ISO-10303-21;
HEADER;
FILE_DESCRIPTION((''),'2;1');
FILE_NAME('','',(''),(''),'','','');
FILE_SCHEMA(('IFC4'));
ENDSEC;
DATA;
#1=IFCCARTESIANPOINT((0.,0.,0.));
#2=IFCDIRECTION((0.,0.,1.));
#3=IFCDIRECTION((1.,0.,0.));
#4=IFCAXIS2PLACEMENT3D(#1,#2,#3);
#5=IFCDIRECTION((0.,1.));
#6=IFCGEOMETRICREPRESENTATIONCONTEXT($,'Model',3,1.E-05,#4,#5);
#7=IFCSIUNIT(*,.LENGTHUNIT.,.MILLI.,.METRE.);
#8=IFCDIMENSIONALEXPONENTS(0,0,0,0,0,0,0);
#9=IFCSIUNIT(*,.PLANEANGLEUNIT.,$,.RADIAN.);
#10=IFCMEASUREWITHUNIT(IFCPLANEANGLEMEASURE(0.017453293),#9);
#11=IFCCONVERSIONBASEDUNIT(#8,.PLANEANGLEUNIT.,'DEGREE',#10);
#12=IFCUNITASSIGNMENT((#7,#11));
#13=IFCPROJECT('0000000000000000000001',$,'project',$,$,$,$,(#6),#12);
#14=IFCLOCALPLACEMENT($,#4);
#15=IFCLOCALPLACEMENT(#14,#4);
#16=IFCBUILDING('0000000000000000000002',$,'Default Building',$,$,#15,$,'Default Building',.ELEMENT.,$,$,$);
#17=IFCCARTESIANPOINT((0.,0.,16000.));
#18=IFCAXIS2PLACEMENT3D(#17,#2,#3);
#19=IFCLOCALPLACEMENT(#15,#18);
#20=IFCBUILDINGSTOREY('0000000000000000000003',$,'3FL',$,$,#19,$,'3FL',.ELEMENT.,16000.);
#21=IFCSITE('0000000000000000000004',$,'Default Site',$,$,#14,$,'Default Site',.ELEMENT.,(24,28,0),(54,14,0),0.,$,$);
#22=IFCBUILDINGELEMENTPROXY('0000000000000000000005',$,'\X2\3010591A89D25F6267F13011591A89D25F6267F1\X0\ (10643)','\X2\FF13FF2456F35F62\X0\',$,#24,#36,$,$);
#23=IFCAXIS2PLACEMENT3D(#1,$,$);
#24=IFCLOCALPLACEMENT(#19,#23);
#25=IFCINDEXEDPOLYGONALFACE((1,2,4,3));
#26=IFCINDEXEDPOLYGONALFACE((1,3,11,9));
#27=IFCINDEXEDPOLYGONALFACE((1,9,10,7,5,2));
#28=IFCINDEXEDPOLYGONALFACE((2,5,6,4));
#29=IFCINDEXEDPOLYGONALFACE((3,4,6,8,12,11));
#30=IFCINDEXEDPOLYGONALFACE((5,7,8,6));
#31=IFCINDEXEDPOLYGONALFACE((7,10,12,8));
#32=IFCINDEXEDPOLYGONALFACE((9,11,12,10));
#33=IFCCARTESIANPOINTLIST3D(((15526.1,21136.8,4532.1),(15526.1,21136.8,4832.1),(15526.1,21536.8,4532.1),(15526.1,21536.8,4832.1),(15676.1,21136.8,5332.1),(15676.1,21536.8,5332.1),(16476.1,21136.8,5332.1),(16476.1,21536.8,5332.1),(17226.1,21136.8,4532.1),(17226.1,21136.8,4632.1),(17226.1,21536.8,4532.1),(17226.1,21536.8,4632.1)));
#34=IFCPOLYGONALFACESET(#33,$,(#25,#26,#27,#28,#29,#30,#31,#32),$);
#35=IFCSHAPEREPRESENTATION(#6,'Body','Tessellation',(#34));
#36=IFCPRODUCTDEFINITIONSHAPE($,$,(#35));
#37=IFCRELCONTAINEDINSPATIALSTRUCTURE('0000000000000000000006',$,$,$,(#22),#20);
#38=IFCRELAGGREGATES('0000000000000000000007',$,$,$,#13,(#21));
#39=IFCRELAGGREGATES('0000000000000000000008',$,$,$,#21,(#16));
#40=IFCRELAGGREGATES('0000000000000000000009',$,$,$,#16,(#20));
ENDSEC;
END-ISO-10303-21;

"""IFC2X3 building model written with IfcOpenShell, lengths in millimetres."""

from ifc_helpers import new_model, entity, si_unit, converted_unit, direction, frame, origin_with_axes, place, context, project, spatial, polyline, outline, extrude, source, transform, mapped, element, save


model = new_model("IFC2X3")

# Units and contexts
model_context = context("Model", 3, precision=1e-05, world=origin_with_axes(), true_north=direction((0.0, 1.0)))
ifc_project = project(units=[si_unit("LENGTHUNIT", "METRE", prefix="MILLI"), converted_unit("PLANEANGLEUNIT", "DEGREE", entity("IfcPlaneAngleMeasure", 0.017453293), si_unit("PLANEANGLEUNIT", "RADIAN"), dimensions=[0, 0, 0, 0, 0, 0, 0])], contexts=[model_context])

# Site, building, storey
site_placement = place(None, origin_with_axes())
site = spatial("IfcSite", under=ifc_project, at=site_placement, Name="Default Site", LongName="Default Site", CompositionType="ELEMENT", RefLatitude=(24, 28, 0), RefLongitude=(54, 14, 0), RefElevation=0.0)
building_placement = place(site_placement, origin_with_axes())
building = spatial("IfcBuilding", under=site, at=building_placement, Name="Default Building", LongName="Default Building", CompositionType="ELEMENT")
storey_placement = place(building_placement, frame((0.0, 0.0, 16000.0), z_axis=(0.0, 0.0, 1.0), x_axis=(1.0, 0.0, 0.0)))
storey = spatial("IfcBuildingStorey", under=building, at=storey_placement, Name="3FL", LongName="3FL", CompositionType="ELEMENT", Elevation=16000.0)

# Building element proxy
shared_shape_1 = source(origin_with_axes(), model_context, "Body", "SweptSolid", [
    extrude(outline(polyline([(850.0, -400.0), (850.0, -300.0), (100.0, 400.0), (-700.0, 400.0), (-850.0, -100.0), (-850.0, -400.0), (850.0, -400.0)])), origin_with_axes(), (0.0, 0.0, 1.0), 400.0),
])
proxy_1_placement = place(storey_placement, frame((16376.1, 21536.8, 4932.1), z_axis=(0.0, -1.0, 0.0), x_axis=(1.0, 0.0, 0.0)))
element("IfcBuildingElementProxy", 1, at=proxy_1_placement, inside=storey, Name="【多角形柱】多角形柱 (10643)", Description="３Ｄ図形", context=model_context, shape_type="MappedRepresentation", body=[
    mapped(shared_shape_1, transform((0.0, 0.0, 0.0))),
])

save(model, "model.ifc")
